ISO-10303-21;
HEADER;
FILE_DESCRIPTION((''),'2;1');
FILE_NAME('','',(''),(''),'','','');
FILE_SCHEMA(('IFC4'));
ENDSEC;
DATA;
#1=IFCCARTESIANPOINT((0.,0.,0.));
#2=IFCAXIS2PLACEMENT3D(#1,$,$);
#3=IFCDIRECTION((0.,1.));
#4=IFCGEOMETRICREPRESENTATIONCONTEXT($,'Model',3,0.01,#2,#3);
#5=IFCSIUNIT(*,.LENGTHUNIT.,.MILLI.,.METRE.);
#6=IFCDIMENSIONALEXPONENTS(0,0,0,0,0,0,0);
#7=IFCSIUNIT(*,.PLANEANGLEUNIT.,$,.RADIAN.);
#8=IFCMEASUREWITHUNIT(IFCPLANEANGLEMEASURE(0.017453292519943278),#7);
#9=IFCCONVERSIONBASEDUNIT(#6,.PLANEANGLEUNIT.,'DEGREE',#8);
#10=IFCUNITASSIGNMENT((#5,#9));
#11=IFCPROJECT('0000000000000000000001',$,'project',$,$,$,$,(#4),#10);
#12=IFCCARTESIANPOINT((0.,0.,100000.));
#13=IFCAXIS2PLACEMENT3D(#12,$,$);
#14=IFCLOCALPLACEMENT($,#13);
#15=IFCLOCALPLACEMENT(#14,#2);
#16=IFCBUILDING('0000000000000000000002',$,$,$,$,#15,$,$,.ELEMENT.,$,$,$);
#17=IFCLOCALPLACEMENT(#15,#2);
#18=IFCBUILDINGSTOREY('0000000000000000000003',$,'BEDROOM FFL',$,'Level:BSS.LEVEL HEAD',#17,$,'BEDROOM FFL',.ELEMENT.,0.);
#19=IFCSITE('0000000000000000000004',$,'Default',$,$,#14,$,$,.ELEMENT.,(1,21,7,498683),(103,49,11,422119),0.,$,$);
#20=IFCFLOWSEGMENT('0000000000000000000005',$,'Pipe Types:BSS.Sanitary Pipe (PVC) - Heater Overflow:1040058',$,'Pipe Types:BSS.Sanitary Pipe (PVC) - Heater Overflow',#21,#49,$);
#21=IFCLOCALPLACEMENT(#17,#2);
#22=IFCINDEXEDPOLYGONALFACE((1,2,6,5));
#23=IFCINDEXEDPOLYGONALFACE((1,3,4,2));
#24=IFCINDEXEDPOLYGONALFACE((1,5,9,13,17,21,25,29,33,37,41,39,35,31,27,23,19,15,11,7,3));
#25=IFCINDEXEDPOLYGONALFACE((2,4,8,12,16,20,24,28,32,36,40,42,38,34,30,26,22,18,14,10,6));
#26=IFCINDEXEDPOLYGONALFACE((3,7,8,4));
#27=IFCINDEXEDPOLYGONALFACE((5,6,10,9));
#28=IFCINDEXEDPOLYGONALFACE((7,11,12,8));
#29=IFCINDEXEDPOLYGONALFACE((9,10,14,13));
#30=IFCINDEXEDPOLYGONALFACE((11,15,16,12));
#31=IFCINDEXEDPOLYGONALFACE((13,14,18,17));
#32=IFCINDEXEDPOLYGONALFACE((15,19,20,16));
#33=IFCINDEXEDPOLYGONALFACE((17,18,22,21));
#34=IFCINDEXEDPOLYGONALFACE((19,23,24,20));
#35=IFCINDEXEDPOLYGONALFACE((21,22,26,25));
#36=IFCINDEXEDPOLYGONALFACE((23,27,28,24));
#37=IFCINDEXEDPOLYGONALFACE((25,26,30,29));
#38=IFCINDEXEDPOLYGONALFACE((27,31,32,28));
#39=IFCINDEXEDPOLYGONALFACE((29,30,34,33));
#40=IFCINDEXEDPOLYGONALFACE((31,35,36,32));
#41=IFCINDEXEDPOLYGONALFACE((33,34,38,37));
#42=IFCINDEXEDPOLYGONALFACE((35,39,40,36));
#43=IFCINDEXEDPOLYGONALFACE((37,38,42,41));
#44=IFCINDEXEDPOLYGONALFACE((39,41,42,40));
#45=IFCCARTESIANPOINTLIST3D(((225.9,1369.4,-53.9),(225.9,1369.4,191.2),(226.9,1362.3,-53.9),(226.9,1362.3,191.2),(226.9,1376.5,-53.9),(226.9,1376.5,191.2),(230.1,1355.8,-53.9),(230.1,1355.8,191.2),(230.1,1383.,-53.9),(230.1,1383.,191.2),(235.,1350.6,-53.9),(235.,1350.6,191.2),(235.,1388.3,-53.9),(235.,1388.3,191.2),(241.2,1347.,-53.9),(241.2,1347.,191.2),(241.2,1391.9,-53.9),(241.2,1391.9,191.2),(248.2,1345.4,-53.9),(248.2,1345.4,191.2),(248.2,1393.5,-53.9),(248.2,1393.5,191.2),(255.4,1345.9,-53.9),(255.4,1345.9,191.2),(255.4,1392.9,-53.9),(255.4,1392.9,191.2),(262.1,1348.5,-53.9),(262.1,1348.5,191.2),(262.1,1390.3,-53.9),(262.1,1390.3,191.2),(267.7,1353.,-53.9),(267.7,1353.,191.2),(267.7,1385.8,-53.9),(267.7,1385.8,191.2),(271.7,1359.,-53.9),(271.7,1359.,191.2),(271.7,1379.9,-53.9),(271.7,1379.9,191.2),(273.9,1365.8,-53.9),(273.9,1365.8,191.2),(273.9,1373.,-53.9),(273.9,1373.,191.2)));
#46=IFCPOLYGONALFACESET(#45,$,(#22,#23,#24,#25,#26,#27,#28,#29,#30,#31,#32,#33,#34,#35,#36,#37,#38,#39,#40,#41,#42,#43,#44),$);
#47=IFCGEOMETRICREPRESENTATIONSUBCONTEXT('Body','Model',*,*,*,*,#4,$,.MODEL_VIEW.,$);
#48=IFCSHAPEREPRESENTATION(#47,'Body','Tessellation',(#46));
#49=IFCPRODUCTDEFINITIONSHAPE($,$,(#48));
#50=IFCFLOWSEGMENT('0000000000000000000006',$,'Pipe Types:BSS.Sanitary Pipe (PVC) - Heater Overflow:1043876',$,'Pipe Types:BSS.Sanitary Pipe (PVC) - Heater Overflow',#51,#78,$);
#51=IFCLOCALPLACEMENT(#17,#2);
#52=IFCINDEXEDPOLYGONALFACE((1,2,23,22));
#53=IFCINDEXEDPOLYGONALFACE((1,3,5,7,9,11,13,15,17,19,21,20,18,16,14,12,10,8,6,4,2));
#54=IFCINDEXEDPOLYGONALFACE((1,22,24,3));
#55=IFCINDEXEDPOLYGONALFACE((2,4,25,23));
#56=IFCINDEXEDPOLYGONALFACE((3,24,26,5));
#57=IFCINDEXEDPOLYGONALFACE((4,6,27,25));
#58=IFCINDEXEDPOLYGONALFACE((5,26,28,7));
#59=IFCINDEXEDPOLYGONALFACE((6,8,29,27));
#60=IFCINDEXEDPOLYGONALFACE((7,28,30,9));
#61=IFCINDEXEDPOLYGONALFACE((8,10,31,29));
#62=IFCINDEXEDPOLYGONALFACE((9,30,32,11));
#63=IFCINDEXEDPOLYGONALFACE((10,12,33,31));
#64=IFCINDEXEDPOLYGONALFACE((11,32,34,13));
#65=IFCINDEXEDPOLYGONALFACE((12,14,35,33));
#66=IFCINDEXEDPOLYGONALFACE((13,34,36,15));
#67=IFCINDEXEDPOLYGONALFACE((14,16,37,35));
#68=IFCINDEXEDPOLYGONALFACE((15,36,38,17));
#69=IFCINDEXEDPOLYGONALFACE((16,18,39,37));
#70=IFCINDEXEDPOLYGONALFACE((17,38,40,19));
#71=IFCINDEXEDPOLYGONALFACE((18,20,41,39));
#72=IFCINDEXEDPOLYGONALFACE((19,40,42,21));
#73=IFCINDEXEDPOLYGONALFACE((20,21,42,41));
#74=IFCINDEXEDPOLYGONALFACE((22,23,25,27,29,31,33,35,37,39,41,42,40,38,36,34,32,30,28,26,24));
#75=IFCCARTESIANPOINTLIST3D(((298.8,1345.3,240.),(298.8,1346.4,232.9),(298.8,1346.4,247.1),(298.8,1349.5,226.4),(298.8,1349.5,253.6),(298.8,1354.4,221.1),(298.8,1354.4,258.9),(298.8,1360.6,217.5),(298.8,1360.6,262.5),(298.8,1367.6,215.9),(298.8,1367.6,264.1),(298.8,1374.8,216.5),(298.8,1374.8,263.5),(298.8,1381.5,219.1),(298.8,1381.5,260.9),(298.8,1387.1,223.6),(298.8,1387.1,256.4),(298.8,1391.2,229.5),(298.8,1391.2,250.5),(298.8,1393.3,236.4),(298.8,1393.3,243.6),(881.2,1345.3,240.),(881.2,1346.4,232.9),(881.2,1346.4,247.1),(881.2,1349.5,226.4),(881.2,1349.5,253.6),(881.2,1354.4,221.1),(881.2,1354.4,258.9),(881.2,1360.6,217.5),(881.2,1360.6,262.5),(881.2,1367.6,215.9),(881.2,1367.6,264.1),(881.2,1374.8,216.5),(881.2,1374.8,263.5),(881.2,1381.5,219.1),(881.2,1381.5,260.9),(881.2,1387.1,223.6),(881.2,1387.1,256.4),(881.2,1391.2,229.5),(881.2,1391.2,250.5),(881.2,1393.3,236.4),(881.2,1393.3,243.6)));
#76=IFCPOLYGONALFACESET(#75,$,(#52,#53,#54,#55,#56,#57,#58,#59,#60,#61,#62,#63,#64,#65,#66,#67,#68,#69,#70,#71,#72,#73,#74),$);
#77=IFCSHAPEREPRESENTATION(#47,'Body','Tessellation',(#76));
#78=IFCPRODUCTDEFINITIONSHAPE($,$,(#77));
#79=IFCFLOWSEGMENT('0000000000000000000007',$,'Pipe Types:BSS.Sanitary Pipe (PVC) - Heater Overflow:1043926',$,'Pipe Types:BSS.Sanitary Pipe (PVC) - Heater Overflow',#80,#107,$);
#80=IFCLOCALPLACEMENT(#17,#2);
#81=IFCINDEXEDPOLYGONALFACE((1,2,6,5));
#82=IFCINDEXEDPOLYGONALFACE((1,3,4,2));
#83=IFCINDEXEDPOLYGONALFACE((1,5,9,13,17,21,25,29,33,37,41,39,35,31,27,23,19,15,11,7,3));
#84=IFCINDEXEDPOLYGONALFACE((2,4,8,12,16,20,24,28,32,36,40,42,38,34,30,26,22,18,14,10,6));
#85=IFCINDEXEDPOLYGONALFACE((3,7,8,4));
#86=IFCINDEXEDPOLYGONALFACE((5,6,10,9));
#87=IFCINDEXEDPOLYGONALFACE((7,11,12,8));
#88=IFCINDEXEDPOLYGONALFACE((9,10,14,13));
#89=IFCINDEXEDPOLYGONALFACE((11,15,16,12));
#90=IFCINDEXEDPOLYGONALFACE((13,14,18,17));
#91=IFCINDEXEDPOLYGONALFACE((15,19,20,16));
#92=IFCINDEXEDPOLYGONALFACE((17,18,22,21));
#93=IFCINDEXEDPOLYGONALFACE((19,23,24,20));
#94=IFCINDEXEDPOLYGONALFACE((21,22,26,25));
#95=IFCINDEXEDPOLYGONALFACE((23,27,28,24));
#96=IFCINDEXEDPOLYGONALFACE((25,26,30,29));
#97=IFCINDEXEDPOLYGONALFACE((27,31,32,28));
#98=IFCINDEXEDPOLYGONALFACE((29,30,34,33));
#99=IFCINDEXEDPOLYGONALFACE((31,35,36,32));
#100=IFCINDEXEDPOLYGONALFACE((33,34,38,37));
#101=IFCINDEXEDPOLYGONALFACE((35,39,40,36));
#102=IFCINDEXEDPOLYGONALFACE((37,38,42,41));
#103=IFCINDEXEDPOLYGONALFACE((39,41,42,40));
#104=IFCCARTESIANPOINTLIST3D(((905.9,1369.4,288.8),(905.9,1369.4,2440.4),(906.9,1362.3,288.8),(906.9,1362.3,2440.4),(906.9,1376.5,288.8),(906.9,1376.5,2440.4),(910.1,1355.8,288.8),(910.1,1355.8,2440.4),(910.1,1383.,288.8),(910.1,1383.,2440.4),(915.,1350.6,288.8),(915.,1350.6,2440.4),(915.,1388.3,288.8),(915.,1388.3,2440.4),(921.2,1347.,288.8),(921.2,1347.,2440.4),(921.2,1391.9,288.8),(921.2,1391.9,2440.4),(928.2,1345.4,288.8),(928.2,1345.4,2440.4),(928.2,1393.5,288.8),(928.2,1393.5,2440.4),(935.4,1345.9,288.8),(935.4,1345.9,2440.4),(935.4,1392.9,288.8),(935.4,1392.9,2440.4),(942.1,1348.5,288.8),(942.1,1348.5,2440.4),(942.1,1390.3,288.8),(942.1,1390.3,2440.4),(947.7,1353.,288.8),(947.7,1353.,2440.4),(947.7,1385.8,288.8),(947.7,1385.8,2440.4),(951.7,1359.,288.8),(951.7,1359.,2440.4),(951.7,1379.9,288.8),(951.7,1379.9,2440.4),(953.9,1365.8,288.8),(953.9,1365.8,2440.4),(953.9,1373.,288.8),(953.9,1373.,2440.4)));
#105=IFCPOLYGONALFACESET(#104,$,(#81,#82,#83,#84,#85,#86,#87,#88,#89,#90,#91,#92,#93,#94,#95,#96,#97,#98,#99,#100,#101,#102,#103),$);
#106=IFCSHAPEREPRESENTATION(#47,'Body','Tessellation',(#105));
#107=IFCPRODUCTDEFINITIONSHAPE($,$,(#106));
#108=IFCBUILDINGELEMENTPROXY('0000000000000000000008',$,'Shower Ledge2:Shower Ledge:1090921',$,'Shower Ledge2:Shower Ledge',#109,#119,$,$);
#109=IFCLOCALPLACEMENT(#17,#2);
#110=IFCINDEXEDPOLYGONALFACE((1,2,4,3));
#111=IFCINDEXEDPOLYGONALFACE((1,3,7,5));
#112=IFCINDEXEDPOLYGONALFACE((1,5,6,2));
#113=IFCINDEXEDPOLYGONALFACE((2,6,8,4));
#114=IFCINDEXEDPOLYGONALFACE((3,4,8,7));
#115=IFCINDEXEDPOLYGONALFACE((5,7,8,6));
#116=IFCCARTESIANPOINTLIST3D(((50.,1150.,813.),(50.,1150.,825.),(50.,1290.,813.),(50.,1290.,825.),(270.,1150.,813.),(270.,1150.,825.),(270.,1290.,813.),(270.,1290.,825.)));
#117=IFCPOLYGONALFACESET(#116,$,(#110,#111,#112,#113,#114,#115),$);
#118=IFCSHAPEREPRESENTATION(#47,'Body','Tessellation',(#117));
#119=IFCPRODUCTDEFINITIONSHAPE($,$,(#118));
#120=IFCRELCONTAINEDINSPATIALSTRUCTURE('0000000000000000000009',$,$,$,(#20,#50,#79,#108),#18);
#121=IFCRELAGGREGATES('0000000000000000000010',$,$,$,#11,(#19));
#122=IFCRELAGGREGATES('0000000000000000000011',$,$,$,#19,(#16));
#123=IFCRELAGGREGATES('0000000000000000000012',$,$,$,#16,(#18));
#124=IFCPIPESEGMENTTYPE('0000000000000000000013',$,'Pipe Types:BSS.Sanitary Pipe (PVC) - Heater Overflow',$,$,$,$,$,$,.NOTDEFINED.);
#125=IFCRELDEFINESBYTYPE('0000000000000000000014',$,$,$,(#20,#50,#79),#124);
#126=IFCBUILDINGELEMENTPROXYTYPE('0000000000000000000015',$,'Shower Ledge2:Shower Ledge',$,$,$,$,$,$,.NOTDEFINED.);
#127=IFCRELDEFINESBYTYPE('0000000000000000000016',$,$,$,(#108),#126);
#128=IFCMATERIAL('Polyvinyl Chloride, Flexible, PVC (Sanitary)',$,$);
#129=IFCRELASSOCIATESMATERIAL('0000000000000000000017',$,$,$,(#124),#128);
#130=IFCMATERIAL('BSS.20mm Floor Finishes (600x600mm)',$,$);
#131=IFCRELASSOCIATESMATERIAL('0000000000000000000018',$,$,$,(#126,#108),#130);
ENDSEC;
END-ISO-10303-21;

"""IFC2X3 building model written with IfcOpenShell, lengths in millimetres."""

from ifc_helpers import new_model, entity, si_unit, converted_unit, direction, frame, frame_2d, origin, origin_2d_with_axis, place, context, subcontext, project, spatial, rectangle, circle, extrude, source, transform, mapped, material, type_object, type_shapes, element, save


model = new_model("IFC2X3")

# Units and contexts
model_context = context("Model", 3, precision=0.01, world=origin(), true_north=direction((0.0, 1.0)))
body_context = subcontext(model_context, "Body", "Model", "MODEL_VIEW")
ifc_project = project(units=[si_unit("LENGTHUNIT", "METRE", prefix="MILLI"), converted_unit("PLANEANGLEUNIT", "DEGREE", entity("IfcPlaneAngleMeasure", 0.017453292519943278), si_unit("PLANEANGLEUNIT", "RADIAN"), dimensions=[0, 0, 0, 0, 0, 0, 0])], contexts=[model_context])

# Site, building, storey
site_placement = place(None, frame((0.0, 0.0, 100000.0)))
site = spatial("IfcSite", under=ifc_project, at=site_placement, Name="Default", CompositionType="ELEMENT", RefLatitude=(1, 21, 7, 498683), RefLongitude=(103, 49, 11, 422119), RefElevation=0.0)
building_placement = place(site_placement, origin())
building = spatial("IfcBuilding", under=site, at=building_placement, CompositionType="ELEMENT")
storey_placement = place(building_placement, origin())
storey = spatial("IfcBuildingStorey", under=building, at=storey_placement, Name="BEDROOM FFL", ObjectType="Level:BSS.LEVEL HEAD", LongName="BEDROOM FFL", CompositionType="ELEMENT", Elevation=0.0)

# Shared definitions
ifc_material_1 = material(Name="BSS.20mm Floor Finishes (600x600mm)")

# Flow segments
ifc_material_2 = material(Name="Polyvinyl Chloride, Flexible, PVC (Sanitary)")
pipe_segment_type = type_object("IfcPipeSegmentType", Name="Pipe Types:BSS.Sanitary Pipe (PVC) - Heater Overflow", PredefinedType="NOTDEFINED", material=ifc_material_2)
flow_segment_1_placement = place(storey_placement, origin())
element("IfcFlowSegment", 1, at=flow_segment_1_placement, inside=storey, type_object=pipe_segment_type, Name="Pipe Types:BSS.Sanitary Pipe (PVC) - Heater Overflow:1040058", ObjectType="Pipe Types:BSS.Sanitary Pipe (PVC) - Heater Overflow", context=body_context, shape_type="SweptSolid", body=[
    extrude(circle(Radius=24.1, at=frame_2d((0.0, 0.0), x_axis=(1.0, 0.0))), frame((250.0, 1369.4, -53.9), z_axis=(0.0, 0.0, 1.0), x_axis=(-1.0, 0.0, 0.0)), (0.0, 0.0, 1.0), 245.1),
])
flow_segment_2_placement = place(storey_placement, origin())
element("IfcFlowSegment", 2, at=flow_segment_2_placement, inside=storey, type_object=pipe_segment_type, Name="Pipe Types:BSS.Sanitary Pipe (PVC) - Heater Overflow:1043876", ObjectType="Pipe Types:BSS.Sanitary Pipe (PVC) - Heater Overflow", context=body_context, shape_type="SweptSolid", body=[
    extrude(circle(Radius=24.1, at=frame_2d((0.0, 0.0), x_axis=(1.0, 0.0))), frame((298.8, 1369.4, 240.0), z_axis=(1.0, 0.0, 0.0), x_axis=(0.0, -1.0, 0.0)), (0.0, 0.0, 1.0), 582.5),
])
flow_segment_3_placement = place(storey_placement, origin())
element("IfcFlowSegment", 3, at=flow_segment_3_placement, inside=storey, type_object=pipe_segment_type, Name="Pipe Types:BSS.Sanitary Pipe (PVC) - Heater Overflow:1043926", ObjectType="Pipe Types:BSS.Sanitary Pipe (PVC) - Heater Overflow", context=body_context, shape_type="SweptSolid", body=[
    extrude(circle(Radius=24.1, at=frame_2d((0.0, 0.0), x_axis=(1.0, 0.0))), frame((930.0, 1369.4, 288.8), z_axis=(0.0, 0.0, 1.0), x_axis=(-1.0, 0.0, 0.0)), (0.0, 0.0, 1.0), 2151.6),
])

# Building element proxy
building_element_proxy_type = type_object("IfcBuildingElementProxyType", Name="Shower Ledge2:Shower Ledge", PredefinedType="NOTDEFINED", material=ifc_material_1)
shared_shape = source(origin(), body_context, "Body", "SweptSolid", [
    extrude(rectangle(XDim=220.0, YDim=140.0, at=origin_2d_with_axis()), frame((160.0, 1220.0, 813.0), z_axis=(0.0, 0.0, 1.0), x_axis=(-1.0, 0.0, 0.0)), (0.0, 0.0, 1.0), 12.0),
])
type_shapes(building_element_proxy_type, [shared_shape])
proxy_placement = place(storey_placement, origin())
element("IfcBuildingElementProxy", 4, at=proxy_placement, inside=storey, type_object=building_element_proxy_type, material=ifc_material_1, Name="Shower Ledge2:Shower Ledge:1090921", ObjectType="Shower Ledge2:Shower Ledge", context=body_context, shape_type="MappedRepresentation", body=[
    mapped(shared_shape, transform((0.0, 0.0, 0.0), scale=1.0)),
])

save(model, "model.ifc")
